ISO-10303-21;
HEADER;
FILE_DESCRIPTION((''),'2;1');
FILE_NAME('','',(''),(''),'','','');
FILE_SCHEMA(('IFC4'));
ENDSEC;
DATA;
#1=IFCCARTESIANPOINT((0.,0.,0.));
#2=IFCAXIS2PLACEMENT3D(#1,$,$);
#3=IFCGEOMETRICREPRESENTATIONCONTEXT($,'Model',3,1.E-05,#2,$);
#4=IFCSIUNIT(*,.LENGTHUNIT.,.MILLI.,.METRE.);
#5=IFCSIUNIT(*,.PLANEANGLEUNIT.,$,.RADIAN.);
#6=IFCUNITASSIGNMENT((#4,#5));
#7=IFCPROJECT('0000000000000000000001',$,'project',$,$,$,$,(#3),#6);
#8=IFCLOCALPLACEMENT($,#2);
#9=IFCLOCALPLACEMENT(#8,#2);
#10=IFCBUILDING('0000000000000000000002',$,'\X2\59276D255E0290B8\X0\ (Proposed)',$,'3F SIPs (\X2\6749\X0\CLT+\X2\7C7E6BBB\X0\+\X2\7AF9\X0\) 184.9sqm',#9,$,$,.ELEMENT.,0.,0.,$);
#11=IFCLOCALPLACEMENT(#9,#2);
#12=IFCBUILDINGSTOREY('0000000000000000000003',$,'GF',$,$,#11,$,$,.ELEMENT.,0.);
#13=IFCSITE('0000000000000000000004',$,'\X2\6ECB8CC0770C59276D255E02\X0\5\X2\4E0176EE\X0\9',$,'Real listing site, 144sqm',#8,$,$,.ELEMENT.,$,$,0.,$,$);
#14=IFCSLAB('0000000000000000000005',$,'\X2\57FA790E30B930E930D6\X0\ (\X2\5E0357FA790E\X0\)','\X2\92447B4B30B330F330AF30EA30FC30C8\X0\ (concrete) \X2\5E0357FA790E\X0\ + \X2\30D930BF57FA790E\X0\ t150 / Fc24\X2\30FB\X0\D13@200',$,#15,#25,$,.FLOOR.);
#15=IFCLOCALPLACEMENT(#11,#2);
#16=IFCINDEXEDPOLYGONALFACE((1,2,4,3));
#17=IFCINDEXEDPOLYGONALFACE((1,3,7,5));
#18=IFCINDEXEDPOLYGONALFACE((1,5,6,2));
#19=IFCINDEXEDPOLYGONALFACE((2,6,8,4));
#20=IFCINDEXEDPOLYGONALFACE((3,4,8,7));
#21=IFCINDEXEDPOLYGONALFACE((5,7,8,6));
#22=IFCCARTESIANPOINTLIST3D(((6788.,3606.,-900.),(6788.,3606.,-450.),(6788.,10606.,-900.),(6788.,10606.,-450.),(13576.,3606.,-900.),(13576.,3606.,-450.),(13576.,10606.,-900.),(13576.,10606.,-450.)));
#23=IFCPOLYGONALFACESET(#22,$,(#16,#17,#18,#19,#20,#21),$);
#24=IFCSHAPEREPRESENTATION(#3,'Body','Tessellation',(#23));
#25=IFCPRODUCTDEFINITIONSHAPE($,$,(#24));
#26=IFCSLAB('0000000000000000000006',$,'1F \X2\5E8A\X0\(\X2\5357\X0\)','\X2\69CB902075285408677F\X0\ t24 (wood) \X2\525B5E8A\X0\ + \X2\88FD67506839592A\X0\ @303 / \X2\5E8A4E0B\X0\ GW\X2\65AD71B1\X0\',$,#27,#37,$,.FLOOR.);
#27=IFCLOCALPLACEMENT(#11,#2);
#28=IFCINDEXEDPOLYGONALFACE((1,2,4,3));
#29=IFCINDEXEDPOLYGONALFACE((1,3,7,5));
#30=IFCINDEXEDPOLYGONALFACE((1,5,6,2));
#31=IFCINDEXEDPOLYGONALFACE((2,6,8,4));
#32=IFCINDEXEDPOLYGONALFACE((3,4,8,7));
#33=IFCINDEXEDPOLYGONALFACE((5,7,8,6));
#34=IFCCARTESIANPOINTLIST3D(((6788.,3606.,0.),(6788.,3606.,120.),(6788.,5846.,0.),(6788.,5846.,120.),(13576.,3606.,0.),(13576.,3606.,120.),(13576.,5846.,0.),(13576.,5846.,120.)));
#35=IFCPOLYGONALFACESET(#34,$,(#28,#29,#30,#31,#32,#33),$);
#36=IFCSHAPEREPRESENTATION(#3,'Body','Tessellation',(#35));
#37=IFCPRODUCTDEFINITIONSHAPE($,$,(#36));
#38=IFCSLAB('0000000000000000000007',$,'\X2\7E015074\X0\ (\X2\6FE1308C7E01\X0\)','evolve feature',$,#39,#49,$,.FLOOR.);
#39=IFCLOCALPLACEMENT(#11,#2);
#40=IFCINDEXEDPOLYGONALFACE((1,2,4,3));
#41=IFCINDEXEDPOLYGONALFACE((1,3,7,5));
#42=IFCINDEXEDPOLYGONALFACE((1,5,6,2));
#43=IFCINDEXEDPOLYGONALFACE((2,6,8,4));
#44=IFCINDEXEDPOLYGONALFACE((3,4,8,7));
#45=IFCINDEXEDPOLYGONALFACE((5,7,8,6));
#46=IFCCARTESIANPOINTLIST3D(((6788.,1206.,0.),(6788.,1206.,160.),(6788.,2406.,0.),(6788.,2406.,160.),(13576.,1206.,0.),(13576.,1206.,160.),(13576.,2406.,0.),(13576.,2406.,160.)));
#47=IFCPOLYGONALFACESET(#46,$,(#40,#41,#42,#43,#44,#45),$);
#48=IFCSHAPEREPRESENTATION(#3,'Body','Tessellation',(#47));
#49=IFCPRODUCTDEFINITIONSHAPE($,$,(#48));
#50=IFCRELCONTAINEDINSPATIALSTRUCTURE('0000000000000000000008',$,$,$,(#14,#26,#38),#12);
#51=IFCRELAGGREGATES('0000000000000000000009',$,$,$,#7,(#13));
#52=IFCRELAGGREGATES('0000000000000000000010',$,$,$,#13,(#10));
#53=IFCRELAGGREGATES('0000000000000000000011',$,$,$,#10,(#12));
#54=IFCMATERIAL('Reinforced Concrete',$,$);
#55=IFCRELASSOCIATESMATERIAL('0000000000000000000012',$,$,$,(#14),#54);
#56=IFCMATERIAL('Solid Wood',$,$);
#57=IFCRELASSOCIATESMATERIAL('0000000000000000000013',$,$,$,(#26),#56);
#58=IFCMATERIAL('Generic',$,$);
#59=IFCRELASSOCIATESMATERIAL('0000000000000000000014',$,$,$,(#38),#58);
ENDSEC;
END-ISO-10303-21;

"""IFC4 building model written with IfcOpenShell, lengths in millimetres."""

from ifc_helpers import new_model, si_unit, frame, frame_2d, origin, place, context, project, spatial, rectangle, extrude, material, element, save


model = new_model("IFC4")

# Units and contexts
model_context = context("Model", 3, precision=1e-05, world=origin())
ifc_project = project(units=[si_unit("LENGTHUNIT", "METRE", prefix="MILLI"), si_unit("PLANEANGLEUNIT", "RADIAN")], contexts=[model_context])

# Site, building, storey
site_placement = place(None, origin())
site = spatial("IfcSite", under=ifc_project, at=site_placement, Name="滋賀県大津市5丁目9", ObjectType="Real listing site, 144sqm", CompositionType="ELEMENT", RefElevation=0.0)
building_placement = place(site_placement, origin())
building = spatial("IfcBuilding", under=site, at=building_placement, Name="大津市邸 (Proposed)", ObjectType="3F SIPs (杉CLT+籾殻+竹) 184.9sqm", CompositionType="ELEMENT", ElevationOfRefHeight=0.0, ElevationOfTerrain=0.0)
storey_placement = place(building_placement, origin())
storey = spatial("IfcBuildingStorey", under=building, at=storey_placement, Name="GF", CompositionType="ELEMENT", Elevation=0.0)

# Slabs
ifc_material_1 = material(Name="Reinforced Concrete")
slab_1_placement = place(storey_placement, frame((3394.0, 1803.0, -450.0)))
element("IfcSlab", 1, at=slab_1_placement, inside=storey, material=ifc_material_1, Name="基礎スラブ (布基礎)", Description="鉄筋コンクリート (concrete) 布基礎 + ベタ基礎 t150 / Fc24・D13@200", PredefinedType="FLOOR", context=model_context, shape_type="SweptSolid", body=[
    extrude(rectangle(XDim=6788.0, YDim=7000.0, at=frame_2d((3394.0, 3500.0))), frame((3394.0, 1803.0, -450.0)), (0.0, 0.0, 1.0), 450.0),
])
ifc_material_2 = material(Name="Solid Wood")
slab_2_placement = place(storey_placement, frame((3394.0, 1803.0, 0.0)))
element("IfcSlab", 2, at=slab_2_placement, inside=storey, material=ifc_material_2, Name="1F 床(南)", Description="構造用合板 t24 (wood) 剛床 + 製材根太 @303 / 床下 GW断熱", PredefinedType="FLOOR", context=model_context, shape_type="SweptSolid", body=[
    extrude(rectangle(XDim=6788.0, YDim=2240.0, at=frame_2d((3394.0, 1120.0))), frame((3394.0, 1803.0, 0.0)), (0.0, 0.0, 1.0), 120.0),
])
ifc_material_3 = material(Name="Generic")
slab_3_placement = place(storey_placement, frame((3394.0, 603.0, 0.0)))
element("IfcSlab", 3, at=slab_3_placement, inside=storey, material=ifc_material_3, Name="縁側 (濡れ縁)", Description="evolve feature", PredefinedType="FLOOR", context=model_context, shape_type="SweptSolid", body=[
    extrude(rectangle(XDim=6788.0, YDim=1200.0, at=frame_2d((3394.0, 600.0))), frame((3394.0, 603.0, 0.0)), (0.0, 0.0, 1.0), 160.0),
])

save(model, "model.ifc")
